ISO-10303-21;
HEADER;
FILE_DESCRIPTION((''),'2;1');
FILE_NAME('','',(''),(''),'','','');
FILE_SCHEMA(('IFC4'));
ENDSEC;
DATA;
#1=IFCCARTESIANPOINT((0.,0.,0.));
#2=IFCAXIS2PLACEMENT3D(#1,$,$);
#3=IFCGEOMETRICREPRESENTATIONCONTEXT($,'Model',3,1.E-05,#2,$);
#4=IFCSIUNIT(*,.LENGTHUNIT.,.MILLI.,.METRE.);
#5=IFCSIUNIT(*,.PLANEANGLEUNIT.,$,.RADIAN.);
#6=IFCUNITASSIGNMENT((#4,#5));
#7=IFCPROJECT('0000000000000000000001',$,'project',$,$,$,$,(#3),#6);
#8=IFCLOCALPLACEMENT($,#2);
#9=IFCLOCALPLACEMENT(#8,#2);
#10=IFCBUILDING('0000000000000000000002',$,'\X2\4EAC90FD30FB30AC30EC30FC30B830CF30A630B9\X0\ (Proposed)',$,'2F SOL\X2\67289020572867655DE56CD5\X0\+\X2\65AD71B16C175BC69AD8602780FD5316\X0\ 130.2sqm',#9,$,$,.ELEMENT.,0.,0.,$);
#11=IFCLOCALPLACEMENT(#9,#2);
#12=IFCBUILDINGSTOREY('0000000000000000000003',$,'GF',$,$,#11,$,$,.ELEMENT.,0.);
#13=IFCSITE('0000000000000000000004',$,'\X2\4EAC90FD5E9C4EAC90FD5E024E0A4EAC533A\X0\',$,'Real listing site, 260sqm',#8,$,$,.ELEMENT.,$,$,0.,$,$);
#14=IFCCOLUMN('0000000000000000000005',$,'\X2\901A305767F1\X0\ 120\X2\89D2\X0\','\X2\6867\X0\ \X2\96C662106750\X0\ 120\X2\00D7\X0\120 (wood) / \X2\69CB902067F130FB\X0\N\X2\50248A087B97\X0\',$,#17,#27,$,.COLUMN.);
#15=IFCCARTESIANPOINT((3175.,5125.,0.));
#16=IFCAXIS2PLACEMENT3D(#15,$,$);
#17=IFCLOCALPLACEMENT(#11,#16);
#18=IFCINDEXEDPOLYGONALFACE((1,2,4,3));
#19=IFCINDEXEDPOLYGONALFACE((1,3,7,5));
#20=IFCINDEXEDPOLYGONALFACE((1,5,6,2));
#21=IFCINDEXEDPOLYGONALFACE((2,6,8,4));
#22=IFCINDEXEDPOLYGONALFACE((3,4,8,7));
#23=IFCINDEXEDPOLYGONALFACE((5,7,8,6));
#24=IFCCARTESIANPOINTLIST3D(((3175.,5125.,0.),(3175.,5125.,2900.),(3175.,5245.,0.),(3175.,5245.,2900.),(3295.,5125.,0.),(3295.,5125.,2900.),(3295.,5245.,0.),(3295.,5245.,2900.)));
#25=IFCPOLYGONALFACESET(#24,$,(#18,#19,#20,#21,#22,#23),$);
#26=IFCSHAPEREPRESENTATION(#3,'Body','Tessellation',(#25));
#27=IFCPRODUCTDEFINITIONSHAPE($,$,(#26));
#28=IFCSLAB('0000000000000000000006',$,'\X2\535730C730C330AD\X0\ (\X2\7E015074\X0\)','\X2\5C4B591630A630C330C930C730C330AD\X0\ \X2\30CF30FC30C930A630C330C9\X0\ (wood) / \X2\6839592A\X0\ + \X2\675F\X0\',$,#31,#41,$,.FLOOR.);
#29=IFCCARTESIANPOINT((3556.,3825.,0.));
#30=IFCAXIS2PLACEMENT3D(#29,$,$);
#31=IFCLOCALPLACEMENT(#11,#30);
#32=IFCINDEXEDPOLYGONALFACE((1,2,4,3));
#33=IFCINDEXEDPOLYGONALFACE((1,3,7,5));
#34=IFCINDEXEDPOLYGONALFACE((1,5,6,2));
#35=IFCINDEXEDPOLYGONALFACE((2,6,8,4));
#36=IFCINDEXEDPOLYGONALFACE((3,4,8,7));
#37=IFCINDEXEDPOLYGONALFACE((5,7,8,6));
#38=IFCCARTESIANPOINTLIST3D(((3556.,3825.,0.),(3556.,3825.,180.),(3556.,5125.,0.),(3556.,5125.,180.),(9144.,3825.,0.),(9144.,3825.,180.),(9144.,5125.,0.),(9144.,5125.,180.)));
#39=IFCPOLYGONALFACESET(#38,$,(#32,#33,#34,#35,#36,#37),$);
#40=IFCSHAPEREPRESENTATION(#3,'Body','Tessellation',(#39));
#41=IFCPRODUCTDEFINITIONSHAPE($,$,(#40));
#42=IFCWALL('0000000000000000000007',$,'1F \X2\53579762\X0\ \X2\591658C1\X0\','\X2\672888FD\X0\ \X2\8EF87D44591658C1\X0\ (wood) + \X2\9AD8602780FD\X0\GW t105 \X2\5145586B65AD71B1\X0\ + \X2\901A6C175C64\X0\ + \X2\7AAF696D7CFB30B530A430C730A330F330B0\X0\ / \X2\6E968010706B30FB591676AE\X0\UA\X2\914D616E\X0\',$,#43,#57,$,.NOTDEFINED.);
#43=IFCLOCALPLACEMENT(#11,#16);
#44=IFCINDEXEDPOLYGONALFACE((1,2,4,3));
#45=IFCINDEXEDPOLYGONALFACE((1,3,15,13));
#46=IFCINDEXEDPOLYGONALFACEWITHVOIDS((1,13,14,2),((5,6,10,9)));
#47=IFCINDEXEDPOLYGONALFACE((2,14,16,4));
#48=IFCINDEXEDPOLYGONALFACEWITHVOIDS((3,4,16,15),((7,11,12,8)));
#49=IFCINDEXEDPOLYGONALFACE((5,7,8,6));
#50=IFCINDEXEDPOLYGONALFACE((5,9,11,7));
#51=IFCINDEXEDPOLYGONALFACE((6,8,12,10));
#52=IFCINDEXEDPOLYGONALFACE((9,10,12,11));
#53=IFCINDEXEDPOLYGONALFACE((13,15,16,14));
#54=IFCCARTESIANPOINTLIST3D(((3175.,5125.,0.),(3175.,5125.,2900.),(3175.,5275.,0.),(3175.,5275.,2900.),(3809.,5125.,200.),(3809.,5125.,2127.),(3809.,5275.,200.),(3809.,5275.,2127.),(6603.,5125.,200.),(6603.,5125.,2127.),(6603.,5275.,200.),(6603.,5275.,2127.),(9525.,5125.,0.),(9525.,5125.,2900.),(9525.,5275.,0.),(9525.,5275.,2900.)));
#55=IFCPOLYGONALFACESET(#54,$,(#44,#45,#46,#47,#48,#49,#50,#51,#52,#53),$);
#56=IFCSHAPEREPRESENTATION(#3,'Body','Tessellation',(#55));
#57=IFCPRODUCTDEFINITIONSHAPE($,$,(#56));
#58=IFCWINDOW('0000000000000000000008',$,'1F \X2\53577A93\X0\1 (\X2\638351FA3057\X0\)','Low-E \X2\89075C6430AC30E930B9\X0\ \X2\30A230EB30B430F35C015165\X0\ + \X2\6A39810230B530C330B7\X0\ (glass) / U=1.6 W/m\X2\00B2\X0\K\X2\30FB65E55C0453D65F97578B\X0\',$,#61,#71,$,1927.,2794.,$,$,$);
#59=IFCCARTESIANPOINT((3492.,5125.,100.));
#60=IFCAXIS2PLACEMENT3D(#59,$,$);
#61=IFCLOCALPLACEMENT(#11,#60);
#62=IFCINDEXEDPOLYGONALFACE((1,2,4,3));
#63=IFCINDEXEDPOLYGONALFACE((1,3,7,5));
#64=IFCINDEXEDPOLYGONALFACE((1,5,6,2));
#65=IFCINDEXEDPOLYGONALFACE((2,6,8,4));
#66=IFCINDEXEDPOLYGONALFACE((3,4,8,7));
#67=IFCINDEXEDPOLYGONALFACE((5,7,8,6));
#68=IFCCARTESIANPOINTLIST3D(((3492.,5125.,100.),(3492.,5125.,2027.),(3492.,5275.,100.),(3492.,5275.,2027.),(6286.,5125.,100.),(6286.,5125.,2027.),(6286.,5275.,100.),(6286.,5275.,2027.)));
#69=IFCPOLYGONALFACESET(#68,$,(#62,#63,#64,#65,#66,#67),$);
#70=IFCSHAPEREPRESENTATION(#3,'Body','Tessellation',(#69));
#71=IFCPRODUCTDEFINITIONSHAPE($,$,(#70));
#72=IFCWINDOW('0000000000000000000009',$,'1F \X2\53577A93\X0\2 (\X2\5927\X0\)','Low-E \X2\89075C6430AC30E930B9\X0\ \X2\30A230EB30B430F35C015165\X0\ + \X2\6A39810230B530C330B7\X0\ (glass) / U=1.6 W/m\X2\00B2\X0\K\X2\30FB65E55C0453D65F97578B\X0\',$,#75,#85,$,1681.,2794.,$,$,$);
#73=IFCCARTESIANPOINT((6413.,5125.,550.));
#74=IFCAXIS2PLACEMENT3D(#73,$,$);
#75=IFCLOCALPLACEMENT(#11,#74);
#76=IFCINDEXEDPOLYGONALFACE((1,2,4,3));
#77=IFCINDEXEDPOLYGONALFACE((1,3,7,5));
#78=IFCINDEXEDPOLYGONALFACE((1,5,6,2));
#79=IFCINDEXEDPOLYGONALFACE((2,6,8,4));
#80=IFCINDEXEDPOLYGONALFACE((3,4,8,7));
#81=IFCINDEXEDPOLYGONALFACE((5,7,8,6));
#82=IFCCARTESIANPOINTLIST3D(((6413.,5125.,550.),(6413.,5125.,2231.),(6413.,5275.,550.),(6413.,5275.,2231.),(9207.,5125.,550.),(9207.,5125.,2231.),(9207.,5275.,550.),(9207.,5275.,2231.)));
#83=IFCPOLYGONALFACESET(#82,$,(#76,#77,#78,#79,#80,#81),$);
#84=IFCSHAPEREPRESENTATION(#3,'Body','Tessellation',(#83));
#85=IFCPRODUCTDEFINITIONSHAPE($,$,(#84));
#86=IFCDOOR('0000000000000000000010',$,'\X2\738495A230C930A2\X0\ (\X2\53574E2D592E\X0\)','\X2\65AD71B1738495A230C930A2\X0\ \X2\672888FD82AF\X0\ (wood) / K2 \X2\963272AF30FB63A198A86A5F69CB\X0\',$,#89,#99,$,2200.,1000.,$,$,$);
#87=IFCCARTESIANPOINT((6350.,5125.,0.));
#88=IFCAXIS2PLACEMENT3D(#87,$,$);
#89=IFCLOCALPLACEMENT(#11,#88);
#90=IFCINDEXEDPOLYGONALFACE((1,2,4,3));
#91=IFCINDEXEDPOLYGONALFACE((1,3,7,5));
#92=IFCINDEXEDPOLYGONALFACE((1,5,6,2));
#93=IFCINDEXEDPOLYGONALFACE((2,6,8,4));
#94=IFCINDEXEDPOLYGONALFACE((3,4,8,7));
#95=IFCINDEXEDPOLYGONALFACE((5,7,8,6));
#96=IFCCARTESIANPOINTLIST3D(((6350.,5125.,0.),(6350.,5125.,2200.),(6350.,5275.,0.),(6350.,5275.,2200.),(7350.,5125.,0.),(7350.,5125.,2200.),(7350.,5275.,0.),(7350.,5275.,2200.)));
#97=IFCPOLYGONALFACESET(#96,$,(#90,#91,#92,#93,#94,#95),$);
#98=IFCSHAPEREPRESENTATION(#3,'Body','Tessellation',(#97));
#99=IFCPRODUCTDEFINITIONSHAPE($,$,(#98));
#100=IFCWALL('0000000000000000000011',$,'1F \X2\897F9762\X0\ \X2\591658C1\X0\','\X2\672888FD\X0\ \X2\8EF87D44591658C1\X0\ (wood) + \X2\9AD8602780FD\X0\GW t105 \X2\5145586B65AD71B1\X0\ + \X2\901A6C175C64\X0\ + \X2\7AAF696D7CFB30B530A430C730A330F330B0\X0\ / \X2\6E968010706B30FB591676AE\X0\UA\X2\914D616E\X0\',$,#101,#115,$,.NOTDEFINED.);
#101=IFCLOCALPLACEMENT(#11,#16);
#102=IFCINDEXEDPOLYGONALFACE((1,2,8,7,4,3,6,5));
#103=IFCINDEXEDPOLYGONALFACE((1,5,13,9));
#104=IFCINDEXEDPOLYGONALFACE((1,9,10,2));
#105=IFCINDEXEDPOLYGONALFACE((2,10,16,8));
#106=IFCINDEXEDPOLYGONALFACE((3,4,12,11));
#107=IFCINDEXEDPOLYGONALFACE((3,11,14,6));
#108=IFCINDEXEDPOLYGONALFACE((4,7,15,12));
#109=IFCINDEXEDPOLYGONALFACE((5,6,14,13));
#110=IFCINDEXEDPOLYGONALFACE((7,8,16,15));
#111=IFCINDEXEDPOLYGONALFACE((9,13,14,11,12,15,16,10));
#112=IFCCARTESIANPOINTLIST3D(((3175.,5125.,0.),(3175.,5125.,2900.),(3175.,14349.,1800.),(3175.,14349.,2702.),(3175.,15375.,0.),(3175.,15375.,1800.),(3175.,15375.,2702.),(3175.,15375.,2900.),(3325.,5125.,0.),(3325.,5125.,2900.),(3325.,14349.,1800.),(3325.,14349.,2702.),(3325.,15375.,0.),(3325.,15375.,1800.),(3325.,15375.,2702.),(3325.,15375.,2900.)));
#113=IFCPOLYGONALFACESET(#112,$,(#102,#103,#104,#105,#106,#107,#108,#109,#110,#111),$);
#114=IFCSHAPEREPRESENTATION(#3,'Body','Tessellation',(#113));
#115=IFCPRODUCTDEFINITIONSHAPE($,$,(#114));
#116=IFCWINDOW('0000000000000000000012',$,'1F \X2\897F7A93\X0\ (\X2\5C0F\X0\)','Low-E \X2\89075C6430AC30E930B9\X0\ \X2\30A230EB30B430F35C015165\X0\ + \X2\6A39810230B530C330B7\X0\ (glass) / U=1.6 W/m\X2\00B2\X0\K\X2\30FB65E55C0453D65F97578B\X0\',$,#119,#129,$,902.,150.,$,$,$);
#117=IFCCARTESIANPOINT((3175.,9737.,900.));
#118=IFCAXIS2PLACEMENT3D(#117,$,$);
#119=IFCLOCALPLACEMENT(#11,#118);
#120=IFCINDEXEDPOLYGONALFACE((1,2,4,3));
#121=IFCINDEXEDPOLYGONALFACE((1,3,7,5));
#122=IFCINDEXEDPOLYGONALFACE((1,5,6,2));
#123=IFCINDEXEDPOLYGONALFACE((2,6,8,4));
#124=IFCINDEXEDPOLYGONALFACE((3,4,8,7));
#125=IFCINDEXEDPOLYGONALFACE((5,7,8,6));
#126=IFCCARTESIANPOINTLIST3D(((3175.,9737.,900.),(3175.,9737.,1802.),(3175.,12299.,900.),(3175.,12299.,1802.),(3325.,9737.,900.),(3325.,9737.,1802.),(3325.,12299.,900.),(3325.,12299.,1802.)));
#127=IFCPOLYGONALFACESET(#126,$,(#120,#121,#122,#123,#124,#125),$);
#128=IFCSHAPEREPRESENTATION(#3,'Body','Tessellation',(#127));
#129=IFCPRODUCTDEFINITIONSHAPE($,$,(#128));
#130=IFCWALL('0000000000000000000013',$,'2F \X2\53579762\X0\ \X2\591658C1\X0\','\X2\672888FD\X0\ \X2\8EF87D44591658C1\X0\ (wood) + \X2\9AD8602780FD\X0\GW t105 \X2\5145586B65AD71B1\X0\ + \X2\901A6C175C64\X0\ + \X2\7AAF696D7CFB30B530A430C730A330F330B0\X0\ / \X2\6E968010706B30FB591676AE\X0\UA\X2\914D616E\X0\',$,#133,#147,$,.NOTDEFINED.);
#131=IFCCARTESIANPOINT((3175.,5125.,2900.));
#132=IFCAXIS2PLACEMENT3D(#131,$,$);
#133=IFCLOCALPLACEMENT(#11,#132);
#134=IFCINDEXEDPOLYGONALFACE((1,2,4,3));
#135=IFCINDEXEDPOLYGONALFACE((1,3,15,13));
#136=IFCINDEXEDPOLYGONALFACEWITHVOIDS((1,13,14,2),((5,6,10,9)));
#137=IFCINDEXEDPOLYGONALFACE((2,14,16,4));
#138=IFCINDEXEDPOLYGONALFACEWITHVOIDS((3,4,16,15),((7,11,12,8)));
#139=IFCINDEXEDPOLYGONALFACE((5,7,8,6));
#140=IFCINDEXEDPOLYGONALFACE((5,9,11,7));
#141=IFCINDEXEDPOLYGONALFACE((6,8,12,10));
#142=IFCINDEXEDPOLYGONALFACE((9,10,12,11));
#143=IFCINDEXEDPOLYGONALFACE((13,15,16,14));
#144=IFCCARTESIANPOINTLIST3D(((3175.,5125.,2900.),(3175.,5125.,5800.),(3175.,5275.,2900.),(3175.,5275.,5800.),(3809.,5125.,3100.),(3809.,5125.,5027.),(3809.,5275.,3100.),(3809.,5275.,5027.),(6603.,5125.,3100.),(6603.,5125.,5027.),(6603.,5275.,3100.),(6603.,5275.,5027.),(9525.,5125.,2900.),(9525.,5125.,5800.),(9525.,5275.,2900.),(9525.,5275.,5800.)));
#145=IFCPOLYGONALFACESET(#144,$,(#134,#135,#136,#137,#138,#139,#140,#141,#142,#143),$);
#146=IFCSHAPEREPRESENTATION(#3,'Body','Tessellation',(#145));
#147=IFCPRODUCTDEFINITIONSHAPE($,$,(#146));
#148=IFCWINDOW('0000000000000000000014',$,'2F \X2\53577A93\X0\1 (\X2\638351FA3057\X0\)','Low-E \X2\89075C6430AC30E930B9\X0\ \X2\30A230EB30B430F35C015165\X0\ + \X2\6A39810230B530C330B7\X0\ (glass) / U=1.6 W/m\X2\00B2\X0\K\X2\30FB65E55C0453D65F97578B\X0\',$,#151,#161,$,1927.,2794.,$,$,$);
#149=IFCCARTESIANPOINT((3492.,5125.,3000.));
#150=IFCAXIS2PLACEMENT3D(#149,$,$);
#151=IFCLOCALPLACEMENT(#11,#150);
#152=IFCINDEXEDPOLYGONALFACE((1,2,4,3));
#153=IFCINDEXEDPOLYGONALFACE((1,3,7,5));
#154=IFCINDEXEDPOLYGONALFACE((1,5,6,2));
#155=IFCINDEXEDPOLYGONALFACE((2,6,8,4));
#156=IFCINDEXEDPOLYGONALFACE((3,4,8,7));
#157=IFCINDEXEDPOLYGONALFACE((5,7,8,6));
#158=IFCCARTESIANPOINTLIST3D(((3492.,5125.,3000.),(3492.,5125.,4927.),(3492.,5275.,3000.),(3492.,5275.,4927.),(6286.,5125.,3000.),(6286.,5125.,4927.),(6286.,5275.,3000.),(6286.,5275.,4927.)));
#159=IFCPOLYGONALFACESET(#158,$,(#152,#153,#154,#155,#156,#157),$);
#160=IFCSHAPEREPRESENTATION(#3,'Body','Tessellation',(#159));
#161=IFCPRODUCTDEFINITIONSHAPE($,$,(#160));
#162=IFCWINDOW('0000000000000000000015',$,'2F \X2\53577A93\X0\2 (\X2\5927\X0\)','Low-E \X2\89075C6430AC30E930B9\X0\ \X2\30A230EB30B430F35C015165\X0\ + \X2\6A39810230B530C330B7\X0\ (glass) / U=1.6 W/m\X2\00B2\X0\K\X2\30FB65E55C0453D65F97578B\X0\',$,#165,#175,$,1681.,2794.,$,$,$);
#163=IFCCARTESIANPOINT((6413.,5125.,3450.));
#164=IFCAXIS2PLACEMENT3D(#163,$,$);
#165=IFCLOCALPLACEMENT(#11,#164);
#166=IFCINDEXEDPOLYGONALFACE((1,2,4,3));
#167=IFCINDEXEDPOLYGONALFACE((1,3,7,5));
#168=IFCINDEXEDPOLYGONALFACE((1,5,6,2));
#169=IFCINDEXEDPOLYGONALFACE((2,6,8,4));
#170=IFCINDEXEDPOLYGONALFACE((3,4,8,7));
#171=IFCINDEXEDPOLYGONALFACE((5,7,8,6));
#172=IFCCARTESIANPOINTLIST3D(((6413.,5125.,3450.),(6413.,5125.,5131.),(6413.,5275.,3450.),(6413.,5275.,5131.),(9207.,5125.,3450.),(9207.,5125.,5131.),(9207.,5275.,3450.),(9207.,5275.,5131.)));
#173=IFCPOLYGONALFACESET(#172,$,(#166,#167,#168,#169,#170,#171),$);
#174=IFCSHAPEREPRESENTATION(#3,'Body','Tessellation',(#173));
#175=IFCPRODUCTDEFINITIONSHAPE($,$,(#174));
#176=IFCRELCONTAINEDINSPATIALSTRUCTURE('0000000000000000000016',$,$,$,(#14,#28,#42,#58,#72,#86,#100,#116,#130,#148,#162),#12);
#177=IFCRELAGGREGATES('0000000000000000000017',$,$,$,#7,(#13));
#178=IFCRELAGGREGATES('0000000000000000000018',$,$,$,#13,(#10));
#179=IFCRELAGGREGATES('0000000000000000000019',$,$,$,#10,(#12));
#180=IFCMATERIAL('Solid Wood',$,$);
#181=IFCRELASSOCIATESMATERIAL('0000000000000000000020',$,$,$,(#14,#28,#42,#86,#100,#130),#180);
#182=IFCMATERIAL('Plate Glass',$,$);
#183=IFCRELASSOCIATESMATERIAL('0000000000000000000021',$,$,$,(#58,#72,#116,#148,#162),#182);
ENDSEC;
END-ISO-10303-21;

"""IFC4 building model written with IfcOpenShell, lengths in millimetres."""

from ifc_helpers import new_model, si_unit, frame, frame_2d, origin, place, context, project, spatial, rectangle, extrude, material, element, fill, save


model = new_model("IFC4")

# Units and contexts
model_context = context("Model", 3, precision=1e-05, world=origin())
ifc_project = project(units=[si_unit("LENGTHUNIT", "METRE", prefix="MILLI"), si_unit("PLANEANGLEUNIT", "RADIAN")], contexts=[model_context])

# Site, building, storey
site_placement = place(None, origin())
site = spatial("IfcSite", under=ifc_project, at=site_placement, Name="京都府京都市上京区", ObjectType="Real listing site, 260sqm", CompositionType="ELEMENT", RefElevation=0.0)
building_placement = place(site_placement, origin())
building = spatial("IfcBuilding", under=site, at=building_placement, Name="京都・ガレージハウス (Proposed)", ObjectType="2F SOL木造在来工法+断熱気密高性能化 130.2sqm", CompositionType="ELEMENT", ElevationOfRefHeight=0.0, ElevationOfTerrain=0.0)
storey_placement = place(building_placement, origin())
storey = spatial("IfcBuildingStorey", under=building, at=storey_placement, Name="GF", CompositionType="ELEMENT", Elevation=0.0)

# Column
ifc_material_1 = material(Name="Solid Wood")
column_placement = place(storey_placement, frame((3175.0, 5125.0, 0.0)))
element("IfcColumn", 1, at=column_placement, inside=storey, material=ifc_material_1, Name="通し柱 120角", Description="桧 集成材 120×120 (wood) / 構造柱・N値計算", PredefinedType="COLUMN", context=model_context, shape_type="SweptSolid", body=[
    extrude(rectangle(XDim=120.0, YDim=120.0, at=frame_2d((60.0, 60.0))), frame((3175.0, 5125.0, 0.0)), (0.0, 0.0, 1.0), 2900.0),
])

# Slab
slab_1_placement = place(storey_placement, frame((3556.0, 3825.0, 0.0)))
element("IfcSlab", 2, at=slab_1_placement, inside=storey, material=ifc_material_1, Name="南デッキ (縁側)", Description="屋外ウッドデッキ ハードウッド (wood) / 根太 + 束", PredefinedType="FLOOR", context=model_context, shape_type="SweptSolid", body=[
    extrude(rectangle(XDim=5588.0, YDim=1300.0, at=frame_2d((2794.0, 650.0))), frame((3556.0, 3825.0, 0.0)), (0.0, 0.0, 1.0), 180.0),
])

# Wall, openings, windows, door
wall_1_placement = place(storey_placement, frame((3175.0, 5125.0, 0.0)))
wall_1 = element("IfcWall", 3, at=wall_1_placement, inside=storey, material=ifc_material_1, Name="1F 南面 外壁", Description="木製 軸組外壁 (wood) + 高性能GW t105 充填断熱 + 通気層 + 窯業系サイディング / 準耐火・外皮UA配慮", PredefinedType="NOTDEFINED", context=model_context, shape_type="SweptSolid", body=[
    extrude(rectangle(XDim=6350.0, YDim=150.0, at=frame_2d((3175.0, 75.0))), frame((3175.0, 5125.0, 0.0)), (0.0, 0.0, 1.0), 2900.0),
])
opening_1_placement = place(storey_placement, frame((3492.0, 5125.0, 100.0)))
opening_1 = element("IfcOpeningElement", 4, at=opening_1_placement, cuts=wall_1, PredefinedType="NOTDEFINED", context=model_context, shape_type="SweptSolid", body=[
    extrude(rectangle(XDim=2794.0, YDim=150.0, at=frame_2d((1397.0, 75.0))), frame((3492.0, 5125.0, 100.0)), (0.0, 0.0, 1.0), 1927.0),
])
opening_2_placement = place(storey_placement, frame((6413.0, 5125.0, 550.0)))
opening_2 = element("IfcOpeningElement", 5, at=opening_2_placement, cuts=wall_1, PredefinedType="NOTDEFINED", context=model_context, shape_type="SweptSolid", body=[
    extrude(rectangle(XDim=2794.0, YDim=150.0, at=frame_2d((1397.0, 75.0))), frame((6413.0, 5125.0, 550.0)), (0.0, 0.0, 1.0), 1681.0),
])
opening_3_placement = place(storey_placement, frame((6350.0, 5125.0, 0.0)))
opening_3 = element("IfcOpeningElement", 6, at=opening_3_placement, cuts=wall_1, PredefinedType="NOTDEFINED", context=model_context, shape_type="SweptSolid", body=[
    extrude(rectangle(XDim=1000.0, YDim=150.0, at=frame_2d((500.0, 75.0))), frame((6350.0, 5125.0, 0.0)), (0.0, 0.0, 1.0), 2200.0),
])
ifc_material_2 = material(Name="Plate Glass")
window_1_placement = place(storey_placement, frame((3492.0, 5125.0, 100.0)))
window_1 = element("IfcWindow", 7, at=window_1_placement, inside=storey, material=ifc_material_2, Name="1F 南窓1 (掃出し)", Description="Low-E 複層ガラス アルゴン封入 + 樹脂サッシ (glass) / U=1.6 W/m²K・日射取得型", OverallHeight=1927.0, OverallWidth=2794.0, context=model_context, shape_type="SweptSolid", body=[
    extrude(rectangle(XDim=2794.0, YDim=150.0, at=frame_2d((1397.0, 75.0))), frame((3492.0, 5125.0, 100.0)), (0.0, 0.0, 1.0), 1927.0),
])
fill(opening_1, window_1)
window_2_placement = place(storey_placement, frame((6413.0, 5125.0, 550.0)))
window_2 = element("IfcWindow", 8, at=window_2_placement, inside=storey, material=ifc_material_2, Name="1F 南窓2 (大)", Description="Low-E 複層ガラス アルゴン封入 + 樹脂サッシ (glass) / U=1.6 W/m²K・日射取得型", OverallHeight=1681.0, OverallWidth=2794.0, context=model_context, shape_type="SweptSolid", body=[
    extrude(rectangle(XDim=2794.0, YDim=150.0, at=frame_2d((1397.0, 75.0))), frame((6413.0, 5125.0, 550.0)), (0.0, 0.0, 1.0), 1681.0),
])
fill(opening_2, window_2)
door_placement = place(storey_placement, frame((6350.0, 5125.0, 0.0)))
door = element("IfcDoor", 9, at=door_placement, inside=storey, material=ifc_material_1, Name="玄関ドア (南中央)", Description="断熱玄関ドア 木製芯 (wood) / K2 防犯・採風機構", OverallHeight=2200.0, OverallWidth=1000.0, context=model_context, shape_type="SweptSolid", body=[
    extrude(rectangle(XDim=1000.0, YDim=150.0, at=frame_2d((500.0, 75.0))), frame((6350.0, 5125.0, 0.0)), (0.0, 0.0, 1.0), 2200.0),
])
fill(opening_3, door)

# Wall, opening, window
wall_2_placement = place(storey_placement, frame((3175.0, 5125.0, 0.0)))
wall_2 = element("IfcWall", 10, at=wall_2_placement, inside=storey, material=ifc_material_1, Name="1F 西面 外壁", Description="木製 軸組外壁 (wood) + 高性能GW t105 充填断熱 + 通気層 + 窯業系サイディング / 準耐火・外皮UA配慮", PredefinedType="NOTDEFINED", context=model_context, shape_type="SweptSolid", body=[
    extrude(rectangle(XDim=150.0, YDim=10250.0, at=frame_2d((75.0, 5125.0))), frame((3175.0, 5125.0, 0.0)), (0.0, 0.0, 1.0), 2900.0),
])
opening_4_placement = place(storey_placement, frame((3175.0, 9737.0, 900.0)))
opening_4 = element("IfcOpeningElement", 11, at=opening_4_placement, cuts=wall_2, PredefinedType="NOTDEFINED", context=model_context, shape_type="SweptSolid", body=[
    extrude(rectangle(XDim=150.0, YDim=2562.0, at=frame_2d((75.0, 1281.0))), frame((3175.0, 9737.0, 900.0)), (0.0, 0.0, 1.0), 902.0),
])
window_3_placement = place(storey_placement, frame((3175.0, 9737.0, 900.0)))
window_3 = element("IfcWindow", 12, at=window_3_placement, inside=storey, material=ifc_material_2, Name="1F 西窓 (小)", Description="Low-E 複層ガラス アルゴン封入 + 樹脂サッシ (glass) / U=1.6 W/m²K・日射取得型", OverallHeight=902.0, OverallWidth=150.0, context=model_context, shape_type="SweptSolid", body=[
    extrude(rectangle(XDim=150.0, YDim=2562.0, at=frame_2d((75.0, 1281.0))), frame((3175.0, 9737.0, 900.0)), (0.0, 0.0, 1.0), 902.0),
])
fill(opening_4, window_3)

# Wall, openings, windows
wall_3_placement = place(storey_placement, frame((3175.0, 5125.0, 2900.0)))
wall_3 = element("IfcWall", 13, at=wall_3_placement, inside=storey, material=ifc_material_1, Name="2F 南面 外壁", Description="木製 軸組外壁 (wood) + 高性能GW t105 充填断熱 + 通気層 + 窯業系サイディング / 準耐火・外皮UA配慮", PredefinedType="NOTDEFINED", context=model_context, shape_type="SweptSolid", body=[
    extrude(rectangle(XDim=6350.0, YDim=150.0, at=frame_2d((3175.0, 75.0))), frame((3175.0, 5125.0, 2900.0)), (0.0, 0.0, 1.0), 2900.0),
])
opening_5_placement = place(storey_placement, frame((3492.0, 5125.0, 3000.0)))
opening_5 = element("IfcOpeningElement", 14, at=opening_5_placement, cuts=wall_3, PredefinedType="NOTDEFINED", context=model_context, shape_type="SweptSolid", body=[
    extrude(rectangle(XDim=2794.0, YDim=150.0, at=frame_2d((1397.0, 75.0))), frame((3492.0, 5125.0, 3000.0)), (0.0, 0.0, 1.0), 1927.0),
])
opening_6_placement = place(storey_placement, frame((6413.0, 5125.0, 3450.0)))
opening_6 = element("IfcOpeningElement", 15, at=opening_6_placement, cuts=wall_3, PredefinedType="NOTDEFINED", context=model_context, shape_type="SweptSolid", body=[
    extrude(rectangle(XDim=2794.0, YDim=150.0, at=frame_2d((1397.0, 75.0))), frame((6413.0, 5125.0, 3450.0)), (0.0, 0.0, 1.0), 1681.0),
])
window_4_placement = place(storey_placement, frame((3492.0, 5125.0, 3000.0)))
window_4 = element("IfcWindow", 16, at=window_4_placement, inside=storey, material=ifc_material_2, Name="2F 南窓1 (掃出し)", Description="Low-E 複層ガラス アルゴン封入 + 樹脂サッシ (glass) / U=1.6 W/m²K・日射取得型", OverallHeight=1927.0, OverallWidth=2794.0, context=model_context, shape_type="SweptSolid", body=[
    extrude(rectangle(XDim=2794.0, YDim=150.0, at=frame_2d((1397.0, 75.0))), frame((3492.0, 5125.0, 3000.0)), (0.0, 0.0, 1.0), 1927.0),
])
fill(opening_5, window_4)
window_5_placement = place(storey_placement, frame((6413.0, 5125.0, 3450.0)))
window_5 = element("IfcWindow", 17, at=window_5_placement, inside=storey, material=ifc_material_2, Name="2F 南窓2 (大)", Description="Low-E 複層ガラス アルゴン封入 + 樹脂サッシ (glass) / U=1.6 W/m²K・日射取得型", OverallHeight=1681.0, OverallWidth=2794.0, context=model_context, shape_type="SweptSolid", body=[
    extrude(rectangle(XDim=2794.0, YDim=150.0, at=frame_2d((1397.0, 75.0))), frame((6413.0, 5125.0, 3450.0)), (0.0, 0.0, 1.0), 1681.0),
])
fill(opening_6, window_5)

save(model, "model.ifc")
